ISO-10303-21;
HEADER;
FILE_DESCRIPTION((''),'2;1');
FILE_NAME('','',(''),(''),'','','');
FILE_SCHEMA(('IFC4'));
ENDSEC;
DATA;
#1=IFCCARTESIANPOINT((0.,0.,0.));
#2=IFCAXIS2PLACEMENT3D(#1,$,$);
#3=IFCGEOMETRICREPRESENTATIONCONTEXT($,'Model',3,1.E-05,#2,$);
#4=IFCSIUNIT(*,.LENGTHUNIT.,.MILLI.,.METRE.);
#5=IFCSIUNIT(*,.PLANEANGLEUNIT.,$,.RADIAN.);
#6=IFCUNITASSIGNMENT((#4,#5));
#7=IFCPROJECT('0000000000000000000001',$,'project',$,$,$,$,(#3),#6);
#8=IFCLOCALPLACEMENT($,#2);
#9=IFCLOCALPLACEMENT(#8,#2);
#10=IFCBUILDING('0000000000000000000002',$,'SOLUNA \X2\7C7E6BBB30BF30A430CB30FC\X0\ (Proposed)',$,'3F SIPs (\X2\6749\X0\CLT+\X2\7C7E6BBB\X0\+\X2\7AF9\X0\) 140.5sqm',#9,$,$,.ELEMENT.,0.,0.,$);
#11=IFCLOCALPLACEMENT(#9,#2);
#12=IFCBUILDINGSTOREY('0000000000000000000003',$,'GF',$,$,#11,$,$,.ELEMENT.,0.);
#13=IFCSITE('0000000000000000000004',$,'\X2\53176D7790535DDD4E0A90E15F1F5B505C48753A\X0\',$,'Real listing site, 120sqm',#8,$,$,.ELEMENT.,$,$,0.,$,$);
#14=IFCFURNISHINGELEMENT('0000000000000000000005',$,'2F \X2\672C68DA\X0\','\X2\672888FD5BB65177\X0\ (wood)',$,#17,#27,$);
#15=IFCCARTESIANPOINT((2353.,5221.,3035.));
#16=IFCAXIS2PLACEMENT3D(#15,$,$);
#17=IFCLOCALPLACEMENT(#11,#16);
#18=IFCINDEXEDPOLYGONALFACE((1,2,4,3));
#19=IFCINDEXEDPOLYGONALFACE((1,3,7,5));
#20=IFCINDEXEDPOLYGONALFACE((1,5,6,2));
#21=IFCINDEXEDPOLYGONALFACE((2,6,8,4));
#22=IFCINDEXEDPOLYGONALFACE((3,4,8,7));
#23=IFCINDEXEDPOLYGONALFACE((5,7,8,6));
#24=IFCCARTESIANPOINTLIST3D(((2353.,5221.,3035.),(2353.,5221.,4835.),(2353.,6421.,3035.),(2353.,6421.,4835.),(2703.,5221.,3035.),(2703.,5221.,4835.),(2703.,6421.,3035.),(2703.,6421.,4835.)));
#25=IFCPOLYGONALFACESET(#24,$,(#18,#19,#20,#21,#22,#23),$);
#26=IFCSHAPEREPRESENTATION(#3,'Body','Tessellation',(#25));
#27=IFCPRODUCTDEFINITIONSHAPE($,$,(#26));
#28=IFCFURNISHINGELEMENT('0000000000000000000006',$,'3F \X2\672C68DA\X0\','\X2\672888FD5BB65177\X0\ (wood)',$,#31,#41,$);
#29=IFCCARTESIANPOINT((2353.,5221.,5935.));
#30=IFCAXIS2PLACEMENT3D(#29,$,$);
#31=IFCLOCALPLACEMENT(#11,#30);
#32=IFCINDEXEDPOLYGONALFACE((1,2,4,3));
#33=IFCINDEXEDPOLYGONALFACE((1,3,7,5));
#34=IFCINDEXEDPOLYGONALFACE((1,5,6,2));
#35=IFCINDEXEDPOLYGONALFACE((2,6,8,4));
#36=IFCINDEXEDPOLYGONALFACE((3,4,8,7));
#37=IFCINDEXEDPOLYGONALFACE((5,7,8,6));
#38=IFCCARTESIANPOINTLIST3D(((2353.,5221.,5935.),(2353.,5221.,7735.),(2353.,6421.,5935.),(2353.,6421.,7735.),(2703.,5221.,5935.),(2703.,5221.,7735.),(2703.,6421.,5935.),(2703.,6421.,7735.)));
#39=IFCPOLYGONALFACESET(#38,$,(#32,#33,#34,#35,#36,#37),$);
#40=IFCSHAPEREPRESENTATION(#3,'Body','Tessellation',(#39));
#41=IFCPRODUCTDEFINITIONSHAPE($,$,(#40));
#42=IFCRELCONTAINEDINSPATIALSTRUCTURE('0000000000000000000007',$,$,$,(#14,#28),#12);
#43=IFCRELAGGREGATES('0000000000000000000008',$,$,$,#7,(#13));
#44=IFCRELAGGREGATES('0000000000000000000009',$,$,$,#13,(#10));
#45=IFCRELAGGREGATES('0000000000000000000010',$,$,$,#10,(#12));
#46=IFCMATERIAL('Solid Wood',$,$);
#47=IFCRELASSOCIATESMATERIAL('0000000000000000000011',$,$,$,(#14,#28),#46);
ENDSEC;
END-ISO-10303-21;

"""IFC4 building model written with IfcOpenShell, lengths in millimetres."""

from ifc_helpers import new_model, si_unit, frame, frame_2d, origin, place, context, project, spatial, rectangle, extrude, material, element, save


model = new_model("IFC4")

# Units and contexts
model_context = context("Model", 3, precision=1e-05, world=origin())
ifc_project = project(units=[si_unit("LENGTHUNIT", "METRE", prefix="MILLI"), si_unit("PLANEANGLEUNIT", "RADIAN")], contexts=[model_context])

# Site, building, storey
site_placement = place(None, origin())
site = spatial("IfcSite", under=ifc_project, at=site_placement, Name="北海道川上郡弟子屈町", ObjectType="Real listing site, 120sqm", CompositionType="ELEMENT", RefElevation=0.0)
building_placement = place(site_placement, origin())
building = spatial("IfcBuilding", under=site, at=building_placement, Name="SOLUNA 籾殻タイニー (Proposed)", ObjectType="3F SIPs (杉CLT+籾殻+竹) 140.5sqm", CompositionType="ELEMENT", ElevationOfRefHeight=0.0, ElevationOfTerrain=0.0)
storey_placement = place(building_placement, origin())
storey = spatial("IfcBuildingStorey", under=building, at=storey_placement, Name="GF", CompositionType="ELEMENT", Elevation=0.0)

# Shared definitions
ifc_material_1 = material(Name="Solid Wood")

# Furnishing elements
furnishing_1_placement = place(storey_placement, frame((2353.0, 5221.0, 3035.0)))
element("IfcFurnishingElement", 1, at=furnishing_1_placement, inside=storey, material=ifc_material_1, Name="2F 本棚", Description="木製家具 (wood)", context=model_context, shape_type="SweptSolid", body=[
    extrude(rectangle(XDim=350.0, YDim=1200.0, at=frame_2d((175.0, 600.0))), frame((2353.0, 5221.0, 3035.0)), (0.0, 0.0, 1.0), 1800.0),
])
furnishing_2_placement = place(storey_placement, frame((2353.0, 5221.0, 5935.0)))
element("IfcFurnishingElement", 2, at=furnishing_2_placement, inside=storey, material=ifc_material_1, Name="3F 本棚", Description="木製家具 (wood)", context=model_context, shape_type="SweptSolid", body=[
    extrude(rectangle(XDim=350.0, YDim=1200.0, at=frame_2d((175.0, 600.0))), frame((2353.0, 5221.0, 5935.0)), (0.0, 0.0, 1.0), 1800.0),
])

save(model, "model.ifc")
